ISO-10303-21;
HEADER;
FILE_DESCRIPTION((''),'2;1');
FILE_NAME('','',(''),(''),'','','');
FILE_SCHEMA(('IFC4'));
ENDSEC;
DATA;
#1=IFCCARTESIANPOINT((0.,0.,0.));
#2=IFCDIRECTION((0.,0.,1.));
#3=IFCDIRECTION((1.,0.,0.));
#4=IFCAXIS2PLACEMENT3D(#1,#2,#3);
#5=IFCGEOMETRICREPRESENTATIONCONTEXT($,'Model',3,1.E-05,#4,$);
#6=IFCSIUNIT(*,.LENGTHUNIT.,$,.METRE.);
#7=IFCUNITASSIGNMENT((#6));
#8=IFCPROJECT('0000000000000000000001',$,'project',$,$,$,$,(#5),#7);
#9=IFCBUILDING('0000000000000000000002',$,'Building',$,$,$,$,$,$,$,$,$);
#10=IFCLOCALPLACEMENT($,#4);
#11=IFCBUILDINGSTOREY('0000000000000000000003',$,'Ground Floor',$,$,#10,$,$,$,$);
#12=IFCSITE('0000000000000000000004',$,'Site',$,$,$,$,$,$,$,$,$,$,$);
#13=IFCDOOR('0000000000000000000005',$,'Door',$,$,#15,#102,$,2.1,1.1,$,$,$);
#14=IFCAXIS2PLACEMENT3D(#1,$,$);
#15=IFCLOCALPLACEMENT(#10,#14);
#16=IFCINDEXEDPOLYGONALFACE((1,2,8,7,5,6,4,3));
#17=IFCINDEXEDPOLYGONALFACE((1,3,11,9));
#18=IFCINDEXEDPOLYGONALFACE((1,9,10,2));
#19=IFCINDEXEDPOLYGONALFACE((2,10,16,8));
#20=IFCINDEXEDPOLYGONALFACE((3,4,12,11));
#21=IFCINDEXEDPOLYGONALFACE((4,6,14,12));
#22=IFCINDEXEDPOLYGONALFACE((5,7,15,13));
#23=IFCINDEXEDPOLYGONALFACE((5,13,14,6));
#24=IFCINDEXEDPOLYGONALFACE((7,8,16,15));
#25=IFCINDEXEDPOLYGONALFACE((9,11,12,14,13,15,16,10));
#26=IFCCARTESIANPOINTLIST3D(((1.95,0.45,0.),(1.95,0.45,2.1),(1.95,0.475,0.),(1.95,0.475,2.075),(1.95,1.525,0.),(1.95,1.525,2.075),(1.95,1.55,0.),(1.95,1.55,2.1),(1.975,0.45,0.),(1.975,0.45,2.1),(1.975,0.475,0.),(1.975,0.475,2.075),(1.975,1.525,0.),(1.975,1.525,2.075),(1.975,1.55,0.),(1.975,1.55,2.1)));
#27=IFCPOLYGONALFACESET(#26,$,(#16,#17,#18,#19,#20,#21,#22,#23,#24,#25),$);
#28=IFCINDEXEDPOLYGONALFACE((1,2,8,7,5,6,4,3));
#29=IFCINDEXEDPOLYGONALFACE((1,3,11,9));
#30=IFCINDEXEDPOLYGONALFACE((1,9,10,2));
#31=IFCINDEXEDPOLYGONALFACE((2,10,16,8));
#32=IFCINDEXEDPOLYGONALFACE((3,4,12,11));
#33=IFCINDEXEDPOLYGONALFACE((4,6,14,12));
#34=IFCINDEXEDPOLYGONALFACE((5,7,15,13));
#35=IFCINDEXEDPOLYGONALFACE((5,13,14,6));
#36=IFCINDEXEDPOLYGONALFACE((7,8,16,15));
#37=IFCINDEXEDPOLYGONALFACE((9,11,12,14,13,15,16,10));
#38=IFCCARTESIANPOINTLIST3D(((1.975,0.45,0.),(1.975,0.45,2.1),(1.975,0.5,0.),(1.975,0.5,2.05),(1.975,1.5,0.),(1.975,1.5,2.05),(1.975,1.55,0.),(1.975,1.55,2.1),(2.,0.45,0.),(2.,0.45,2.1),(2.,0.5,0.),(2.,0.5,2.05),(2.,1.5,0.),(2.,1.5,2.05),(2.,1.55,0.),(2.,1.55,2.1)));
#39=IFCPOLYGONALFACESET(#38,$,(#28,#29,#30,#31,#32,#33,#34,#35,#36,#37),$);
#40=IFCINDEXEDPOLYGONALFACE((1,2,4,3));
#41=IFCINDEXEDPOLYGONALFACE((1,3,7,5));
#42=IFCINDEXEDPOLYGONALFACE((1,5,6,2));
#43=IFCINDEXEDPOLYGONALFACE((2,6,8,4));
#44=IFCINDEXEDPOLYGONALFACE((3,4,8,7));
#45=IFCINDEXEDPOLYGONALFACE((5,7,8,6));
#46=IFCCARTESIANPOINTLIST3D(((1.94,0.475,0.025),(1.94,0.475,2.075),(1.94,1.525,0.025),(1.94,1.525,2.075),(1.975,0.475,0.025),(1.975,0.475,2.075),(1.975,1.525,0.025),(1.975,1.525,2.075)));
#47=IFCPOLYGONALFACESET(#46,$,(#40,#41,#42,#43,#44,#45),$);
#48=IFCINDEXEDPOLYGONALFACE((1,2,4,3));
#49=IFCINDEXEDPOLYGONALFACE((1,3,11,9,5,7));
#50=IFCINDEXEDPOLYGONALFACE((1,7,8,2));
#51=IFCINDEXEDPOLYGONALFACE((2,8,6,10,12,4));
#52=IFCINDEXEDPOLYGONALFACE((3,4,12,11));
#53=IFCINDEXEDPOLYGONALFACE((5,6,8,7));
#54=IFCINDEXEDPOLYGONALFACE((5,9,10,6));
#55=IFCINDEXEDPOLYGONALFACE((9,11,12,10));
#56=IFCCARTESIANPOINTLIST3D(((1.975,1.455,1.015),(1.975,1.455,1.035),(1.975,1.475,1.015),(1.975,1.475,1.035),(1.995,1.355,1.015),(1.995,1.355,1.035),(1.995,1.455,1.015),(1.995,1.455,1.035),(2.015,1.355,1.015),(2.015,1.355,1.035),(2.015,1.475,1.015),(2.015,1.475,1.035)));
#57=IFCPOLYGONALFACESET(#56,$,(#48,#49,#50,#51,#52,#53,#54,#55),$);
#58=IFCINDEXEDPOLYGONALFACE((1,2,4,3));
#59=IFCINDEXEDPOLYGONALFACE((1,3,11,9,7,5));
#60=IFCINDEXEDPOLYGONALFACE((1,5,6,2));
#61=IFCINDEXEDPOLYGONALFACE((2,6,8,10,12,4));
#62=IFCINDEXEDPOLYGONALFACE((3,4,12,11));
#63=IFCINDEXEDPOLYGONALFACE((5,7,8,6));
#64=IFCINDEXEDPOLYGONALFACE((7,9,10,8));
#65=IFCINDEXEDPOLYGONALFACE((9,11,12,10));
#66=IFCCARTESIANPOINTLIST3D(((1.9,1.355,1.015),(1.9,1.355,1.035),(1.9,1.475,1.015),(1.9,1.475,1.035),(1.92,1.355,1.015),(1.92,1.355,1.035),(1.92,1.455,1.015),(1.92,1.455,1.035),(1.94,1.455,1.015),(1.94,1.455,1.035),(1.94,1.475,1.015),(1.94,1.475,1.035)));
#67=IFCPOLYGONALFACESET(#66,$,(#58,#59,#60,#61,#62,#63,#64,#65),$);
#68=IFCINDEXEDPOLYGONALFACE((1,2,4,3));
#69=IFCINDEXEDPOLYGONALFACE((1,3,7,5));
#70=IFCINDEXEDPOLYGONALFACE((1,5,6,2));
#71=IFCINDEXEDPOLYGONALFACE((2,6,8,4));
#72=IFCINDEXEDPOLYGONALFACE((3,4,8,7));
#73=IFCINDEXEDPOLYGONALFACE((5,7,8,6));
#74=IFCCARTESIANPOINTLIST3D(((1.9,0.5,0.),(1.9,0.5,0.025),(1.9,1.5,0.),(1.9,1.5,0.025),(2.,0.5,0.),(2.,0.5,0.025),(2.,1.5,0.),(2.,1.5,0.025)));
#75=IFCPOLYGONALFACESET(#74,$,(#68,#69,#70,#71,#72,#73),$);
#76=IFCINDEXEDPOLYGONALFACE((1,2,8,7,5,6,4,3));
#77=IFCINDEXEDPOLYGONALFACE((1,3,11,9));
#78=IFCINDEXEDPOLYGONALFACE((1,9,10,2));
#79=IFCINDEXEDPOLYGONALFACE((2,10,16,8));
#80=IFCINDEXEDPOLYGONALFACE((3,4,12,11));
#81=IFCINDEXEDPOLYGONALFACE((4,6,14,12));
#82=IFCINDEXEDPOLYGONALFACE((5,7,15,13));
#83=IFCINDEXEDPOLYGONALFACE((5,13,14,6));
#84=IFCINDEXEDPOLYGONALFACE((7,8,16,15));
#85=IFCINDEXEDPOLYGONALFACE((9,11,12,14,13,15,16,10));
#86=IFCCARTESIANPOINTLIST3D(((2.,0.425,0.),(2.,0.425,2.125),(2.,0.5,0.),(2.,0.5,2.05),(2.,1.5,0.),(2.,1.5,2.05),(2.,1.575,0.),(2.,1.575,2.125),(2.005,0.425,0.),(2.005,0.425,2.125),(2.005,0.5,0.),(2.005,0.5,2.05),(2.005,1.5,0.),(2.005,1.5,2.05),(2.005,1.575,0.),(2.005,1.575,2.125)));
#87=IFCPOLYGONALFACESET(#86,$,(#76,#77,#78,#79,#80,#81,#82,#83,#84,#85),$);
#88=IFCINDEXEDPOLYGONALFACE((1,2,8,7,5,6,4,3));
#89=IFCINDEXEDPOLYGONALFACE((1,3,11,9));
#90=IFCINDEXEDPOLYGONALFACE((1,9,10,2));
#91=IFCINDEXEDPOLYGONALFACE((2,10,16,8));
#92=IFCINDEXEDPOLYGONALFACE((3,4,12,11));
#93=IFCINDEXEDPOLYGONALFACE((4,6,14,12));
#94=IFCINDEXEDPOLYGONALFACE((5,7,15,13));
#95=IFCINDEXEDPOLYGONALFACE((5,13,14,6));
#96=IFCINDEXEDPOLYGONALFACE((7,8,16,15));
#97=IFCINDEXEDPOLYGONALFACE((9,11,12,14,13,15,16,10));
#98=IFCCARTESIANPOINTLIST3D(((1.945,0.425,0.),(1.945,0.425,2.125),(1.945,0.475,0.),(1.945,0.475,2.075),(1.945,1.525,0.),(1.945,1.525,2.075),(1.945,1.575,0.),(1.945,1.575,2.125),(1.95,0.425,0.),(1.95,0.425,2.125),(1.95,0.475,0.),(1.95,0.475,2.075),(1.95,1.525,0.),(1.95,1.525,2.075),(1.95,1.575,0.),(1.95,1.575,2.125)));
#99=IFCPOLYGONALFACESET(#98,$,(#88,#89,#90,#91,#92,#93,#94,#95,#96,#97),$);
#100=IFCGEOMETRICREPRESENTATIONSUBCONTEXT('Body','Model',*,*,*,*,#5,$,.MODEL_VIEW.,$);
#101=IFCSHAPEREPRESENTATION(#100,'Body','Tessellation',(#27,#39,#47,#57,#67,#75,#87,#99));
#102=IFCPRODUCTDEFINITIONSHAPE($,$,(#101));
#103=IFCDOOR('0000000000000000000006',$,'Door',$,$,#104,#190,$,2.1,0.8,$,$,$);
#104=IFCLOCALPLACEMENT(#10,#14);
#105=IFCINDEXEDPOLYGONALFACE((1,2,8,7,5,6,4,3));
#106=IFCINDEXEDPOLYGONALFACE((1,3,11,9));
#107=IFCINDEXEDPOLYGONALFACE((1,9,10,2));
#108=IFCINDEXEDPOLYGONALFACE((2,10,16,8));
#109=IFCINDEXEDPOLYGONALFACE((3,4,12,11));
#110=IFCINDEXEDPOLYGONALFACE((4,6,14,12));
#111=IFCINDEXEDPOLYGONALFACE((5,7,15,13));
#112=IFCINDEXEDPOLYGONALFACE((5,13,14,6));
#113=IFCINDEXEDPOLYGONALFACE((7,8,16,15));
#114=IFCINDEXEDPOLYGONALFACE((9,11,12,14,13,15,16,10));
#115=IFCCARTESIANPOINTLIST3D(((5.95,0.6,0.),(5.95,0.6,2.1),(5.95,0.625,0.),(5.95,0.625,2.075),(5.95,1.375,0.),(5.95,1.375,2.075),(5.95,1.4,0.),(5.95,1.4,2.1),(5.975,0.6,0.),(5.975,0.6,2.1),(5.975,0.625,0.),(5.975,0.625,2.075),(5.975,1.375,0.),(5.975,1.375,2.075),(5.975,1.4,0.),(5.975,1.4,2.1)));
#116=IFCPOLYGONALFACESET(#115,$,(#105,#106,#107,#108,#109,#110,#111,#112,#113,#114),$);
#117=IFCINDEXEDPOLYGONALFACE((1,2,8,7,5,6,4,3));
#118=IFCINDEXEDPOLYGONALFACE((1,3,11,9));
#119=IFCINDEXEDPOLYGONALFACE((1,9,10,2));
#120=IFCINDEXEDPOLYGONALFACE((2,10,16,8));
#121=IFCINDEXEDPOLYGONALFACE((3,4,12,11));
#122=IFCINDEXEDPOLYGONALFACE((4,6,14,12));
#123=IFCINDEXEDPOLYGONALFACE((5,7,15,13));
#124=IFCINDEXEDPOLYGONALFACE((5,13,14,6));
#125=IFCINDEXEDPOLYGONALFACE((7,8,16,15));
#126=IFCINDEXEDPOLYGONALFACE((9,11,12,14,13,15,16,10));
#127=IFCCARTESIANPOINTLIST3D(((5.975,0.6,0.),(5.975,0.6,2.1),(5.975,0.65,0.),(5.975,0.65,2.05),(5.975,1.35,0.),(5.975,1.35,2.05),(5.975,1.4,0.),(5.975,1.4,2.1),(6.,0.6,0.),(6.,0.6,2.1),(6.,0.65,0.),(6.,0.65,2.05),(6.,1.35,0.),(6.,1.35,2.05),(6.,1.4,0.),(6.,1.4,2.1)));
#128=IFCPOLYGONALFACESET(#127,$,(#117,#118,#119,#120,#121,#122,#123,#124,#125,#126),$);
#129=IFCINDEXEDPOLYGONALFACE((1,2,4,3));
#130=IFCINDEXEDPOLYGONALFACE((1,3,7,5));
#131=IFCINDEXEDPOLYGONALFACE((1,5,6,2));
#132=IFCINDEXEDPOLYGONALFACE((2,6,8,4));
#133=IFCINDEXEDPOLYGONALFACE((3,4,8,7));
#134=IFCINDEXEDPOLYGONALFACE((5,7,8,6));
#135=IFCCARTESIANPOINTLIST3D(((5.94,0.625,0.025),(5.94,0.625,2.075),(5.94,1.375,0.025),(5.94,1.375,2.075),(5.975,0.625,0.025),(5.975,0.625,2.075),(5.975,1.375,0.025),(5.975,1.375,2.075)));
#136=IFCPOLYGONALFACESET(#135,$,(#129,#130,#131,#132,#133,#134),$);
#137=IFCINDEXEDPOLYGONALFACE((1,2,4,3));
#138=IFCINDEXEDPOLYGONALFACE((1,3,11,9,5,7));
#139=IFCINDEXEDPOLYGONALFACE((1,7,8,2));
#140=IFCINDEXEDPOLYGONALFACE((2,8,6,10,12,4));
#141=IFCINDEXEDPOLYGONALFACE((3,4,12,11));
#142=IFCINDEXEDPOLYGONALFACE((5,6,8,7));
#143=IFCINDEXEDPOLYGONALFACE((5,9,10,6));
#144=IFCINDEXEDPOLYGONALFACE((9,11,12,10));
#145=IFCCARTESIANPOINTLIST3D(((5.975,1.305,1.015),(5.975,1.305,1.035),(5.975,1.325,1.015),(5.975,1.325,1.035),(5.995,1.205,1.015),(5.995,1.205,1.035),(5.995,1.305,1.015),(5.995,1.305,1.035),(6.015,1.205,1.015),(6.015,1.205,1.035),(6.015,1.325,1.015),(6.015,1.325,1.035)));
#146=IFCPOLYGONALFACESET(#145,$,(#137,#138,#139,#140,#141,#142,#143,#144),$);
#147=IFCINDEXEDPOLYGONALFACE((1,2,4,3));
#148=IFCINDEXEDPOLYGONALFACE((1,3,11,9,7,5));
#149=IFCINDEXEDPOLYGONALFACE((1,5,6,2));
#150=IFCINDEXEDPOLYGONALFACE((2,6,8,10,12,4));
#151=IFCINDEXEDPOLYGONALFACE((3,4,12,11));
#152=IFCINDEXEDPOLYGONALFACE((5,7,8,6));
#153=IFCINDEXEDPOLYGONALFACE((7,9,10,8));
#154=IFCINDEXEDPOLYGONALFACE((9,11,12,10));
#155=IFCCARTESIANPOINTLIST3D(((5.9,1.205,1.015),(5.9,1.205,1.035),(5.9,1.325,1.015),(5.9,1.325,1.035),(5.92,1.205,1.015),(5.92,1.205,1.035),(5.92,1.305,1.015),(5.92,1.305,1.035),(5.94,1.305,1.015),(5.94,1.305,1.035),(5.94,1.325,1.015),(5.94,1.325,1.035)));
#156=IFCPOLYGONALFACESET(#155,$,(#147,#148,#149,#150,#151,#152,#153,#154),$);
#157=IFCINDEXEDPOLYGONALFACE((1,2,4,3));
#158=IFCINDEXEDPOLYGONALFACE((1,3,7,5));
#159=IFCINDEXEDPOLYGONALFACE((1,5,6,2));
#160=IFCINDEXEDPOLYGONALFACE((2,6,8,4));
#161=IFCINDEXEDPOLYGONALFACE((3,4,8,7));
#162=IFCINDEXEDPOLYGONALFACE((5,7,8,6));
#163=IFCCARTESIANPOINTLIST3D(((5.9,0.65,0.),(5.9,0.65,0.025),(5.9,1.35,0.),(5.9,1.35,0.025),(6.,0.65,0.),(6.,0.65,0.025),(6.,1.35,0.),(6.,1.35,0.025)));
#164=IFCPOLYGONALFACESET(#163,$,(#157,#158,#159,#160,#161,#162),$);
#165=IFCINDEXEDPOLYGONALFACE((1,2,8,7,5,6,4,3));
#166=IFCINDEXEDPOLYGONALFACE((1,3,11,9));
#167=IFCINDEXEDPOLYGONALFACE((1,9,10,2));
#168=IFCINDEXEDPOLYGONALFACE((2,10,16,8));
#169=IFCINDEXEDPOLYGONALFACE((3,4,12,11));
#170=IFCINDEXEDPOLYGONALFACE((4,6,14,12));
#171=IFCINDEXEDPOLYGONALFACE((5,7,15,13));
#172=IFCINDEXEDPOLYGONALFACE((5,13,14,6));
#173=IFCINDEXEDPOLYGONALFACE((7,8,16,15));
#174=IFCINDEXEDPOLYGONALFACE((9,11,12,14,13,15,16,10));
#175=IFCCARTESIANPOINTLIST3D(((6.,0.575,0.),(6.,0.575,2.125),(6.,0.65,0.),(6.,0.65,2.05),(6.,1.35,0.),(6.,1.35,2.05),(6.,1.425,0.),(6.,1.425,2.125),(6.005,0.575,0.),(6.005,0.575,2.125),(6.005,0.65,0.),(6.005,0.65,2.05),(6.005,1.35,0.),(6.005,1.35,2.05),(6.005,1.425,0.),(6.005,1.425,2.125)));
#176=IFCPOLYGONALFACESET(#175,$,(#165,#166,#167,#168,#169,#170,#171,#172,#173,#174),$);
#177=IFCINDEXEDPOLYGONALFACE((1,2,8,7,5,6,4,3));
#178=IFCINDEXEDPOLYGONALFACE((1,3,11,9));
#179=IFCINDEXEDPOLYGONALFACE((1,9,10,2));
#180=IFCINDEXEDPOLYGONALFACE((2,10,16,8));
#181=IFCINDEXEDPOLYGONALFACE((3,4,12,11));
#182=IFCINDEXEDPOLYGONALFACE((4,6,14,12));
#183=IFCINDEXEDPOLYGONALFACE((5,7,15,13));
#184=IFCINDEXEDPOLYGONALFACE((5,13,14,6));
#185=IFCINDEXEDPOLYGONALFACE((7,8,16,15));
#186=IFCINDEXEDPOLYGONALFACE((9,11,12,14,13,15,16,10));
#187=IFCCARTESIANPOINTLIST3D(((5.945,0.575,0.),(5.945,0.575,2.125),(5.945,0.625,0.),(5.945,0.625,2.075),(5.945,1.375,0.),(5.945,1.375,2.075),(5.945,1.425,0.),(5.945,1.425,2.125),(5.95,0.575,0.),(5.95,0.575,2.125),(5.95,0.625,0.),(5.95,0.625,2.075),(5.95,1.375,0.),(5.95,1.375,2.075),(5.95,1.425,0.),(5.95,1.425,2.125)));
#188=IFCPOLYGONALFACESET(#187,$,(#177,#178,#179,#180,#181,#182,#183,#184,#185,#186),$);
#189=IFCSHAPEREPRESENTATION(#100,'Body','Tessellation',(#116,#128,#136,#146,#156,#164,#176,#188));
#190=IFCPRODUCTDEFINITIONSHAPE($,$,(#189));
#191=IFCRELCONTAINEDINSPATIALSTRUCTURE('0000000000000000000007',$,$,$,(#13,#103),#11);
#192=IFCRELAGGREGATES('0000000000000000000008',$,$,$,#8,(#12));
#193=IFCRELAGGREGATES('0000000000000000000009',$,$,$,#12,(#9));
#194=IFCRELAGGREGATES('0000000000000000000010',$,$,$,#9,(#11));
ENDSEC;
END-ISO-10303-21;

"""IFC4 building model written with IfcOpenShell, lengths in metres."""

from ifc_helpers import new_model, si_unit, frame, origin_with_axes, place, context, subcontext, project, spatial, line, indexed_curve, outline, extrude, element, save


model = new_model("IFC4")

# Units and contexts
model_context = context("Model", 3, precision=1e-05, world=origin_with_axes())
body_context = subcontext(model_context, "Body", "Model", "MODEL_VIEW")
ifc_project = project(units=[si_unit("LENGTHUNIT", "METRE")], contexts=[model_context])

# Site, building, storey
site = spatial("IfcSite", under=ifc_project, Name="Site")
building = spatial("IfcBuilding", under=site, Name="Building")
storey_placement = place(None, origin_with_axes())
storey = spatial("IfcBuildingStorey", under=building, at=storey_placement, Name="Ground Floor")

# Doors
door_1_placement = place(storey_placement, frame((2.0, 0.45, 0.0), z_axis=(0.0, 0.0, 1.0), x_axis=(0.0, 1.0, 0.0)))
element("IfcDoor", 1, at=door_1_placement, inside=storey, Name="Door", OverallHeight=2.1, OverallWidth=1.1, context=body_context, shape_type="SweptSolid", body=[
    extrude(outline(indexed_curve([(0.0, 0.0), (0.0, 2.1), (1.1, 2.1), (1.1, 0.0), (1.075, 0.0), (1.075, 2.075), (0.025, 2.075), (0.025, 0.0)], segments=[line(1, 2, 3, 4, 5, 6, 7, 8, 1)])), frame((0.0, 0.025, 0.0), z_axis=(0.0, -1.0, 0.0), x_axis=(1.0, 0.0, 0.0)), (0.0, 0.0, -1.0), 0.025),
    extrude(outline(indexed_curve([(0.0, 0.0), (0.0, 2.1), (1.1, 2.1), (1.1, 0.0), (1.05, 0.0), (1.05, 2.05), (0.05, 2.05), (0.05, 0.0)], segments=[line(1, 2, 3, 4, 5, 6, 7, 8, 1)])), frame((0.0, 0.0, 0.0), z_axis=(0.0, -1.0, 0.0), x_axis=(1.0, 0.0, 0.0)), (0.0, 0.0, -1.0), 0.025),
    extrude(outline(indexed_curve([(0.0, 0.0), (1.05, 0.0), (1.05, 0.035), (0.0, 0.035)], segments=[line(1, 2, 3, 4, 1)])), frame((0.025, 0.025, 0.025), z_axis=(0.0, 0.0, 1.0), x_axis=(1.0, 0.0, 0.0)), (0.0, 0.0, 1.0), 2.05),
    extrude(outline(indexed_curve([(0.0, 0.0), (0.0, -0.04), (-0.12, -0.04), (-0.12, -0.02), (-0.02, -0.02), (-0.02, 0.0)], segments=[line(1, 2, 3, 4, 5, 6, 1)])), frame((1.025, 0.025, 1.015), z_axis=(0.0, 0.0, 1.0), x_axis=(1.0, 0.0, 0.0)), (0.0, 0.0, 1.0), 0.02),
    extrude(outline(indexed_curve([(0.0, 0.0), (0.0, 0.04), (-0.12, 0.04), (-0.12, 0.02), (-0.02, 0.02), (-0.02, 0.0)], segments=[line(1, 2, 3, 4, 5, 6, 1)])), frame((1.025, 0.06, 1.015), z_axis=(0.0, 0.0, 1.0), x_axis=(1.0, 0.0, 0.0)), (0.0, 0.0, 1.0), 0.02),
    extrude(outline(indexed_curve([(0.0, 0.0), (1.0, 0.0), (1.0, 0.1), (0.0, 0.1)], segments=[line(1, 2, 3, 4, 1)])), frame((0.05, 0.0, 0.0), z_axis=(0.0, 0.0, 1.0), x_axis=(1.0, 0.0, 0.0)), (0.0, 0.0, 1.0), 0.025),
    extrude(outline(indexed_curve([(0.0, 0.0), (0.0, 2.125), (1.15, 2.125), (1.15, 0.0), (1.075, 0.0), (1.075, 2.05), (0.075, 2.05), (0.075, 0.0)], segments=[line(1, 2, 3, 4, 5, 6, 7, 8, 1)])), frame((-0.025, -0.005, 0.0), z_axis=(0.0, -1.0, 0.0), x_axis=(1.0, 0.0, 0.0)), (0.0, 0.0, -1.0), 0.005),
    extrude(outline(indexed_curve([(0.0, 0.0), (0.0, 2.125), (1.15, 2.125), (1.15, 0.0), (1.1, 0.0), (1.1, 2.075), (0.05, 2.075), (0.05, 0.0)], segments=[line(1, 2, 3, 4, 5, 6, 7, 8, 1)])), frame((-0.025, 0.05, 0.0), z_axis=(0.0, -1.0, 0.0), x_axis=(1.0, 0.0, 0.0)), (0.0, 0.0, -1.0), 0.005),
])
door_2_placement = place(storey_placement, frame((6.0, 0.6, 0.0), z_axis=(0.0, 0.0, 1.0), x_axis=(0.0, 1.0, 0.0)))
element("IfcDoor", 2, at=door_2_placement, inside=storey, Name="Door", OverallHeight=2.1, OverallWidth=0.8, context=body_context, shape_type="SweptSolid", body=[
    extrude(outline(indexed_curve([(0.0, 0.0), (0.0, 2.1), (0.8, 2.1), (0.8, 0.0), (0.775, 0.0), (0.775, 2.075), (0.025, 2.075), (0.025, 0.0)], segments=[line(1, 2, 3, 4, 5, 6, 7, 8, 1)])), frame((0.0, 0.025, 0.0), z_axis=(0.0, -1.0, 0.0), x_axis=(1.0, 0.0, 0.0)), (0.0, 0.0, -1.0), 0.025),
    extrude(outline(indexed_curve([(0.0, 0.0), (0.0, 2.1), (0.8, 2.1), (0.8, 0.0), (0.75, 0.0), (0.75, 2.05), (0.05, 2.05), (0.05, 0.0)], segments=[line(1, 2, 3, 4, 5, 6, 7, 8, 1)])), frame((0.0, 0.0, 0.0), z_axis=(0.0, -1.0, 0.0), x_axis=(1.0, 0.0, 0.0)), (0.0, 0.0, -1.0), 0.025),
    extrude(outline(indexed_curve([(0.0, 0.0), (0.75, 0.0), (0.75, 0.035), (0.0, 0.035)], segments=[line(1, 2, 3, 4, 1)])), frame((0.025, 0.025, 0.025), z_axis=(0.0, 0.0, 1.0), x_axis=(1.0, 0.0, 0.0)), (0.0, 0.0, 1.0), 2.05),
    extrude(outline(indexed_curve([(0.0, 0.0), (0.0, -0.04), (-0.12, -0.04), (-0.12, -0.02), (-0.02, -0.02), (-0.02, 0.0)], segments=[line(1, 2, 3, 4, 5, 6, 1)])), frame((0.725, 0.025, 1.015), z_axis=(0.0, 0.0, 1.0), x_axis=(1.0, 0.0, 0.0)), (0.0, 0.0, 1.0), 0.02),
    extrude(outline(indexed_curve([(0.0, 0.0), (0.0, 0.04), (-0.12, 0.04), (-0.12, 0.02), (-0.02, 0.02), (-0.02, 0.0)], segments=[line(1, 2, 3, 4, 5, 6, 1)])), frame((0.725, 0.06, 1.015), z_axis=(0.0, 0.0, 1.0), x_axis=(1.0, 0.0, 0.0)), (0.0, 0.0, 1.0), 0.02),
    extrude(outline(indexed_curve([(0.0, 0.0), (0.7, 0.0), (0.7, 0.1), (0.0, 0.1)], segments=[line(1, 2, 3, 4, 1)])), frame((0.05, 0.0, 0.0), z_axis=(0.0, 0.0, 1.0), x_axis=(1.0, 0.0, 0.0)), (0.0, 0.0, 1.0), 0.025),
    extrude(outline(indexed_curve([(0.0, 0.0), (0.0, 2.125), (0.85, 2.125), (0.85, 0.0), (0.775, 0.0), (0.775, 2.05), (0.075, 2.05), (0.075, 0.0)], segments=[line(1, 2, 3, 4, 5, 6, 7, 8, 1)])), frame((-0.025, -0.005, 0.0), z_axis=(0.0, -1.0, 0.0), x_axis=(1.0, 0.0, 0.0)), (0.0, 0.0, -1.0), 0.005),
    extrude(outline(indexed_curve([(0.0, 0.0), (0.0, 2.125), (0.85, 2.125), (0.85, 0.0), (0.8, 0.0), (0.8, 2.075), (0.05, 2.075), (0.05, 0.0)], segments=[line(1, 2, 3, 4, 5, 6, 7, 8, 1)])), frame((-0.025, 0.05, 0.0), z_axis=(0.0, -1.0, 0.0), x_axis=(1.0, 0.0, 0.0)), (0.0, 0.0, -1.0), 0.005),
])

save(model, "model.ifc")
